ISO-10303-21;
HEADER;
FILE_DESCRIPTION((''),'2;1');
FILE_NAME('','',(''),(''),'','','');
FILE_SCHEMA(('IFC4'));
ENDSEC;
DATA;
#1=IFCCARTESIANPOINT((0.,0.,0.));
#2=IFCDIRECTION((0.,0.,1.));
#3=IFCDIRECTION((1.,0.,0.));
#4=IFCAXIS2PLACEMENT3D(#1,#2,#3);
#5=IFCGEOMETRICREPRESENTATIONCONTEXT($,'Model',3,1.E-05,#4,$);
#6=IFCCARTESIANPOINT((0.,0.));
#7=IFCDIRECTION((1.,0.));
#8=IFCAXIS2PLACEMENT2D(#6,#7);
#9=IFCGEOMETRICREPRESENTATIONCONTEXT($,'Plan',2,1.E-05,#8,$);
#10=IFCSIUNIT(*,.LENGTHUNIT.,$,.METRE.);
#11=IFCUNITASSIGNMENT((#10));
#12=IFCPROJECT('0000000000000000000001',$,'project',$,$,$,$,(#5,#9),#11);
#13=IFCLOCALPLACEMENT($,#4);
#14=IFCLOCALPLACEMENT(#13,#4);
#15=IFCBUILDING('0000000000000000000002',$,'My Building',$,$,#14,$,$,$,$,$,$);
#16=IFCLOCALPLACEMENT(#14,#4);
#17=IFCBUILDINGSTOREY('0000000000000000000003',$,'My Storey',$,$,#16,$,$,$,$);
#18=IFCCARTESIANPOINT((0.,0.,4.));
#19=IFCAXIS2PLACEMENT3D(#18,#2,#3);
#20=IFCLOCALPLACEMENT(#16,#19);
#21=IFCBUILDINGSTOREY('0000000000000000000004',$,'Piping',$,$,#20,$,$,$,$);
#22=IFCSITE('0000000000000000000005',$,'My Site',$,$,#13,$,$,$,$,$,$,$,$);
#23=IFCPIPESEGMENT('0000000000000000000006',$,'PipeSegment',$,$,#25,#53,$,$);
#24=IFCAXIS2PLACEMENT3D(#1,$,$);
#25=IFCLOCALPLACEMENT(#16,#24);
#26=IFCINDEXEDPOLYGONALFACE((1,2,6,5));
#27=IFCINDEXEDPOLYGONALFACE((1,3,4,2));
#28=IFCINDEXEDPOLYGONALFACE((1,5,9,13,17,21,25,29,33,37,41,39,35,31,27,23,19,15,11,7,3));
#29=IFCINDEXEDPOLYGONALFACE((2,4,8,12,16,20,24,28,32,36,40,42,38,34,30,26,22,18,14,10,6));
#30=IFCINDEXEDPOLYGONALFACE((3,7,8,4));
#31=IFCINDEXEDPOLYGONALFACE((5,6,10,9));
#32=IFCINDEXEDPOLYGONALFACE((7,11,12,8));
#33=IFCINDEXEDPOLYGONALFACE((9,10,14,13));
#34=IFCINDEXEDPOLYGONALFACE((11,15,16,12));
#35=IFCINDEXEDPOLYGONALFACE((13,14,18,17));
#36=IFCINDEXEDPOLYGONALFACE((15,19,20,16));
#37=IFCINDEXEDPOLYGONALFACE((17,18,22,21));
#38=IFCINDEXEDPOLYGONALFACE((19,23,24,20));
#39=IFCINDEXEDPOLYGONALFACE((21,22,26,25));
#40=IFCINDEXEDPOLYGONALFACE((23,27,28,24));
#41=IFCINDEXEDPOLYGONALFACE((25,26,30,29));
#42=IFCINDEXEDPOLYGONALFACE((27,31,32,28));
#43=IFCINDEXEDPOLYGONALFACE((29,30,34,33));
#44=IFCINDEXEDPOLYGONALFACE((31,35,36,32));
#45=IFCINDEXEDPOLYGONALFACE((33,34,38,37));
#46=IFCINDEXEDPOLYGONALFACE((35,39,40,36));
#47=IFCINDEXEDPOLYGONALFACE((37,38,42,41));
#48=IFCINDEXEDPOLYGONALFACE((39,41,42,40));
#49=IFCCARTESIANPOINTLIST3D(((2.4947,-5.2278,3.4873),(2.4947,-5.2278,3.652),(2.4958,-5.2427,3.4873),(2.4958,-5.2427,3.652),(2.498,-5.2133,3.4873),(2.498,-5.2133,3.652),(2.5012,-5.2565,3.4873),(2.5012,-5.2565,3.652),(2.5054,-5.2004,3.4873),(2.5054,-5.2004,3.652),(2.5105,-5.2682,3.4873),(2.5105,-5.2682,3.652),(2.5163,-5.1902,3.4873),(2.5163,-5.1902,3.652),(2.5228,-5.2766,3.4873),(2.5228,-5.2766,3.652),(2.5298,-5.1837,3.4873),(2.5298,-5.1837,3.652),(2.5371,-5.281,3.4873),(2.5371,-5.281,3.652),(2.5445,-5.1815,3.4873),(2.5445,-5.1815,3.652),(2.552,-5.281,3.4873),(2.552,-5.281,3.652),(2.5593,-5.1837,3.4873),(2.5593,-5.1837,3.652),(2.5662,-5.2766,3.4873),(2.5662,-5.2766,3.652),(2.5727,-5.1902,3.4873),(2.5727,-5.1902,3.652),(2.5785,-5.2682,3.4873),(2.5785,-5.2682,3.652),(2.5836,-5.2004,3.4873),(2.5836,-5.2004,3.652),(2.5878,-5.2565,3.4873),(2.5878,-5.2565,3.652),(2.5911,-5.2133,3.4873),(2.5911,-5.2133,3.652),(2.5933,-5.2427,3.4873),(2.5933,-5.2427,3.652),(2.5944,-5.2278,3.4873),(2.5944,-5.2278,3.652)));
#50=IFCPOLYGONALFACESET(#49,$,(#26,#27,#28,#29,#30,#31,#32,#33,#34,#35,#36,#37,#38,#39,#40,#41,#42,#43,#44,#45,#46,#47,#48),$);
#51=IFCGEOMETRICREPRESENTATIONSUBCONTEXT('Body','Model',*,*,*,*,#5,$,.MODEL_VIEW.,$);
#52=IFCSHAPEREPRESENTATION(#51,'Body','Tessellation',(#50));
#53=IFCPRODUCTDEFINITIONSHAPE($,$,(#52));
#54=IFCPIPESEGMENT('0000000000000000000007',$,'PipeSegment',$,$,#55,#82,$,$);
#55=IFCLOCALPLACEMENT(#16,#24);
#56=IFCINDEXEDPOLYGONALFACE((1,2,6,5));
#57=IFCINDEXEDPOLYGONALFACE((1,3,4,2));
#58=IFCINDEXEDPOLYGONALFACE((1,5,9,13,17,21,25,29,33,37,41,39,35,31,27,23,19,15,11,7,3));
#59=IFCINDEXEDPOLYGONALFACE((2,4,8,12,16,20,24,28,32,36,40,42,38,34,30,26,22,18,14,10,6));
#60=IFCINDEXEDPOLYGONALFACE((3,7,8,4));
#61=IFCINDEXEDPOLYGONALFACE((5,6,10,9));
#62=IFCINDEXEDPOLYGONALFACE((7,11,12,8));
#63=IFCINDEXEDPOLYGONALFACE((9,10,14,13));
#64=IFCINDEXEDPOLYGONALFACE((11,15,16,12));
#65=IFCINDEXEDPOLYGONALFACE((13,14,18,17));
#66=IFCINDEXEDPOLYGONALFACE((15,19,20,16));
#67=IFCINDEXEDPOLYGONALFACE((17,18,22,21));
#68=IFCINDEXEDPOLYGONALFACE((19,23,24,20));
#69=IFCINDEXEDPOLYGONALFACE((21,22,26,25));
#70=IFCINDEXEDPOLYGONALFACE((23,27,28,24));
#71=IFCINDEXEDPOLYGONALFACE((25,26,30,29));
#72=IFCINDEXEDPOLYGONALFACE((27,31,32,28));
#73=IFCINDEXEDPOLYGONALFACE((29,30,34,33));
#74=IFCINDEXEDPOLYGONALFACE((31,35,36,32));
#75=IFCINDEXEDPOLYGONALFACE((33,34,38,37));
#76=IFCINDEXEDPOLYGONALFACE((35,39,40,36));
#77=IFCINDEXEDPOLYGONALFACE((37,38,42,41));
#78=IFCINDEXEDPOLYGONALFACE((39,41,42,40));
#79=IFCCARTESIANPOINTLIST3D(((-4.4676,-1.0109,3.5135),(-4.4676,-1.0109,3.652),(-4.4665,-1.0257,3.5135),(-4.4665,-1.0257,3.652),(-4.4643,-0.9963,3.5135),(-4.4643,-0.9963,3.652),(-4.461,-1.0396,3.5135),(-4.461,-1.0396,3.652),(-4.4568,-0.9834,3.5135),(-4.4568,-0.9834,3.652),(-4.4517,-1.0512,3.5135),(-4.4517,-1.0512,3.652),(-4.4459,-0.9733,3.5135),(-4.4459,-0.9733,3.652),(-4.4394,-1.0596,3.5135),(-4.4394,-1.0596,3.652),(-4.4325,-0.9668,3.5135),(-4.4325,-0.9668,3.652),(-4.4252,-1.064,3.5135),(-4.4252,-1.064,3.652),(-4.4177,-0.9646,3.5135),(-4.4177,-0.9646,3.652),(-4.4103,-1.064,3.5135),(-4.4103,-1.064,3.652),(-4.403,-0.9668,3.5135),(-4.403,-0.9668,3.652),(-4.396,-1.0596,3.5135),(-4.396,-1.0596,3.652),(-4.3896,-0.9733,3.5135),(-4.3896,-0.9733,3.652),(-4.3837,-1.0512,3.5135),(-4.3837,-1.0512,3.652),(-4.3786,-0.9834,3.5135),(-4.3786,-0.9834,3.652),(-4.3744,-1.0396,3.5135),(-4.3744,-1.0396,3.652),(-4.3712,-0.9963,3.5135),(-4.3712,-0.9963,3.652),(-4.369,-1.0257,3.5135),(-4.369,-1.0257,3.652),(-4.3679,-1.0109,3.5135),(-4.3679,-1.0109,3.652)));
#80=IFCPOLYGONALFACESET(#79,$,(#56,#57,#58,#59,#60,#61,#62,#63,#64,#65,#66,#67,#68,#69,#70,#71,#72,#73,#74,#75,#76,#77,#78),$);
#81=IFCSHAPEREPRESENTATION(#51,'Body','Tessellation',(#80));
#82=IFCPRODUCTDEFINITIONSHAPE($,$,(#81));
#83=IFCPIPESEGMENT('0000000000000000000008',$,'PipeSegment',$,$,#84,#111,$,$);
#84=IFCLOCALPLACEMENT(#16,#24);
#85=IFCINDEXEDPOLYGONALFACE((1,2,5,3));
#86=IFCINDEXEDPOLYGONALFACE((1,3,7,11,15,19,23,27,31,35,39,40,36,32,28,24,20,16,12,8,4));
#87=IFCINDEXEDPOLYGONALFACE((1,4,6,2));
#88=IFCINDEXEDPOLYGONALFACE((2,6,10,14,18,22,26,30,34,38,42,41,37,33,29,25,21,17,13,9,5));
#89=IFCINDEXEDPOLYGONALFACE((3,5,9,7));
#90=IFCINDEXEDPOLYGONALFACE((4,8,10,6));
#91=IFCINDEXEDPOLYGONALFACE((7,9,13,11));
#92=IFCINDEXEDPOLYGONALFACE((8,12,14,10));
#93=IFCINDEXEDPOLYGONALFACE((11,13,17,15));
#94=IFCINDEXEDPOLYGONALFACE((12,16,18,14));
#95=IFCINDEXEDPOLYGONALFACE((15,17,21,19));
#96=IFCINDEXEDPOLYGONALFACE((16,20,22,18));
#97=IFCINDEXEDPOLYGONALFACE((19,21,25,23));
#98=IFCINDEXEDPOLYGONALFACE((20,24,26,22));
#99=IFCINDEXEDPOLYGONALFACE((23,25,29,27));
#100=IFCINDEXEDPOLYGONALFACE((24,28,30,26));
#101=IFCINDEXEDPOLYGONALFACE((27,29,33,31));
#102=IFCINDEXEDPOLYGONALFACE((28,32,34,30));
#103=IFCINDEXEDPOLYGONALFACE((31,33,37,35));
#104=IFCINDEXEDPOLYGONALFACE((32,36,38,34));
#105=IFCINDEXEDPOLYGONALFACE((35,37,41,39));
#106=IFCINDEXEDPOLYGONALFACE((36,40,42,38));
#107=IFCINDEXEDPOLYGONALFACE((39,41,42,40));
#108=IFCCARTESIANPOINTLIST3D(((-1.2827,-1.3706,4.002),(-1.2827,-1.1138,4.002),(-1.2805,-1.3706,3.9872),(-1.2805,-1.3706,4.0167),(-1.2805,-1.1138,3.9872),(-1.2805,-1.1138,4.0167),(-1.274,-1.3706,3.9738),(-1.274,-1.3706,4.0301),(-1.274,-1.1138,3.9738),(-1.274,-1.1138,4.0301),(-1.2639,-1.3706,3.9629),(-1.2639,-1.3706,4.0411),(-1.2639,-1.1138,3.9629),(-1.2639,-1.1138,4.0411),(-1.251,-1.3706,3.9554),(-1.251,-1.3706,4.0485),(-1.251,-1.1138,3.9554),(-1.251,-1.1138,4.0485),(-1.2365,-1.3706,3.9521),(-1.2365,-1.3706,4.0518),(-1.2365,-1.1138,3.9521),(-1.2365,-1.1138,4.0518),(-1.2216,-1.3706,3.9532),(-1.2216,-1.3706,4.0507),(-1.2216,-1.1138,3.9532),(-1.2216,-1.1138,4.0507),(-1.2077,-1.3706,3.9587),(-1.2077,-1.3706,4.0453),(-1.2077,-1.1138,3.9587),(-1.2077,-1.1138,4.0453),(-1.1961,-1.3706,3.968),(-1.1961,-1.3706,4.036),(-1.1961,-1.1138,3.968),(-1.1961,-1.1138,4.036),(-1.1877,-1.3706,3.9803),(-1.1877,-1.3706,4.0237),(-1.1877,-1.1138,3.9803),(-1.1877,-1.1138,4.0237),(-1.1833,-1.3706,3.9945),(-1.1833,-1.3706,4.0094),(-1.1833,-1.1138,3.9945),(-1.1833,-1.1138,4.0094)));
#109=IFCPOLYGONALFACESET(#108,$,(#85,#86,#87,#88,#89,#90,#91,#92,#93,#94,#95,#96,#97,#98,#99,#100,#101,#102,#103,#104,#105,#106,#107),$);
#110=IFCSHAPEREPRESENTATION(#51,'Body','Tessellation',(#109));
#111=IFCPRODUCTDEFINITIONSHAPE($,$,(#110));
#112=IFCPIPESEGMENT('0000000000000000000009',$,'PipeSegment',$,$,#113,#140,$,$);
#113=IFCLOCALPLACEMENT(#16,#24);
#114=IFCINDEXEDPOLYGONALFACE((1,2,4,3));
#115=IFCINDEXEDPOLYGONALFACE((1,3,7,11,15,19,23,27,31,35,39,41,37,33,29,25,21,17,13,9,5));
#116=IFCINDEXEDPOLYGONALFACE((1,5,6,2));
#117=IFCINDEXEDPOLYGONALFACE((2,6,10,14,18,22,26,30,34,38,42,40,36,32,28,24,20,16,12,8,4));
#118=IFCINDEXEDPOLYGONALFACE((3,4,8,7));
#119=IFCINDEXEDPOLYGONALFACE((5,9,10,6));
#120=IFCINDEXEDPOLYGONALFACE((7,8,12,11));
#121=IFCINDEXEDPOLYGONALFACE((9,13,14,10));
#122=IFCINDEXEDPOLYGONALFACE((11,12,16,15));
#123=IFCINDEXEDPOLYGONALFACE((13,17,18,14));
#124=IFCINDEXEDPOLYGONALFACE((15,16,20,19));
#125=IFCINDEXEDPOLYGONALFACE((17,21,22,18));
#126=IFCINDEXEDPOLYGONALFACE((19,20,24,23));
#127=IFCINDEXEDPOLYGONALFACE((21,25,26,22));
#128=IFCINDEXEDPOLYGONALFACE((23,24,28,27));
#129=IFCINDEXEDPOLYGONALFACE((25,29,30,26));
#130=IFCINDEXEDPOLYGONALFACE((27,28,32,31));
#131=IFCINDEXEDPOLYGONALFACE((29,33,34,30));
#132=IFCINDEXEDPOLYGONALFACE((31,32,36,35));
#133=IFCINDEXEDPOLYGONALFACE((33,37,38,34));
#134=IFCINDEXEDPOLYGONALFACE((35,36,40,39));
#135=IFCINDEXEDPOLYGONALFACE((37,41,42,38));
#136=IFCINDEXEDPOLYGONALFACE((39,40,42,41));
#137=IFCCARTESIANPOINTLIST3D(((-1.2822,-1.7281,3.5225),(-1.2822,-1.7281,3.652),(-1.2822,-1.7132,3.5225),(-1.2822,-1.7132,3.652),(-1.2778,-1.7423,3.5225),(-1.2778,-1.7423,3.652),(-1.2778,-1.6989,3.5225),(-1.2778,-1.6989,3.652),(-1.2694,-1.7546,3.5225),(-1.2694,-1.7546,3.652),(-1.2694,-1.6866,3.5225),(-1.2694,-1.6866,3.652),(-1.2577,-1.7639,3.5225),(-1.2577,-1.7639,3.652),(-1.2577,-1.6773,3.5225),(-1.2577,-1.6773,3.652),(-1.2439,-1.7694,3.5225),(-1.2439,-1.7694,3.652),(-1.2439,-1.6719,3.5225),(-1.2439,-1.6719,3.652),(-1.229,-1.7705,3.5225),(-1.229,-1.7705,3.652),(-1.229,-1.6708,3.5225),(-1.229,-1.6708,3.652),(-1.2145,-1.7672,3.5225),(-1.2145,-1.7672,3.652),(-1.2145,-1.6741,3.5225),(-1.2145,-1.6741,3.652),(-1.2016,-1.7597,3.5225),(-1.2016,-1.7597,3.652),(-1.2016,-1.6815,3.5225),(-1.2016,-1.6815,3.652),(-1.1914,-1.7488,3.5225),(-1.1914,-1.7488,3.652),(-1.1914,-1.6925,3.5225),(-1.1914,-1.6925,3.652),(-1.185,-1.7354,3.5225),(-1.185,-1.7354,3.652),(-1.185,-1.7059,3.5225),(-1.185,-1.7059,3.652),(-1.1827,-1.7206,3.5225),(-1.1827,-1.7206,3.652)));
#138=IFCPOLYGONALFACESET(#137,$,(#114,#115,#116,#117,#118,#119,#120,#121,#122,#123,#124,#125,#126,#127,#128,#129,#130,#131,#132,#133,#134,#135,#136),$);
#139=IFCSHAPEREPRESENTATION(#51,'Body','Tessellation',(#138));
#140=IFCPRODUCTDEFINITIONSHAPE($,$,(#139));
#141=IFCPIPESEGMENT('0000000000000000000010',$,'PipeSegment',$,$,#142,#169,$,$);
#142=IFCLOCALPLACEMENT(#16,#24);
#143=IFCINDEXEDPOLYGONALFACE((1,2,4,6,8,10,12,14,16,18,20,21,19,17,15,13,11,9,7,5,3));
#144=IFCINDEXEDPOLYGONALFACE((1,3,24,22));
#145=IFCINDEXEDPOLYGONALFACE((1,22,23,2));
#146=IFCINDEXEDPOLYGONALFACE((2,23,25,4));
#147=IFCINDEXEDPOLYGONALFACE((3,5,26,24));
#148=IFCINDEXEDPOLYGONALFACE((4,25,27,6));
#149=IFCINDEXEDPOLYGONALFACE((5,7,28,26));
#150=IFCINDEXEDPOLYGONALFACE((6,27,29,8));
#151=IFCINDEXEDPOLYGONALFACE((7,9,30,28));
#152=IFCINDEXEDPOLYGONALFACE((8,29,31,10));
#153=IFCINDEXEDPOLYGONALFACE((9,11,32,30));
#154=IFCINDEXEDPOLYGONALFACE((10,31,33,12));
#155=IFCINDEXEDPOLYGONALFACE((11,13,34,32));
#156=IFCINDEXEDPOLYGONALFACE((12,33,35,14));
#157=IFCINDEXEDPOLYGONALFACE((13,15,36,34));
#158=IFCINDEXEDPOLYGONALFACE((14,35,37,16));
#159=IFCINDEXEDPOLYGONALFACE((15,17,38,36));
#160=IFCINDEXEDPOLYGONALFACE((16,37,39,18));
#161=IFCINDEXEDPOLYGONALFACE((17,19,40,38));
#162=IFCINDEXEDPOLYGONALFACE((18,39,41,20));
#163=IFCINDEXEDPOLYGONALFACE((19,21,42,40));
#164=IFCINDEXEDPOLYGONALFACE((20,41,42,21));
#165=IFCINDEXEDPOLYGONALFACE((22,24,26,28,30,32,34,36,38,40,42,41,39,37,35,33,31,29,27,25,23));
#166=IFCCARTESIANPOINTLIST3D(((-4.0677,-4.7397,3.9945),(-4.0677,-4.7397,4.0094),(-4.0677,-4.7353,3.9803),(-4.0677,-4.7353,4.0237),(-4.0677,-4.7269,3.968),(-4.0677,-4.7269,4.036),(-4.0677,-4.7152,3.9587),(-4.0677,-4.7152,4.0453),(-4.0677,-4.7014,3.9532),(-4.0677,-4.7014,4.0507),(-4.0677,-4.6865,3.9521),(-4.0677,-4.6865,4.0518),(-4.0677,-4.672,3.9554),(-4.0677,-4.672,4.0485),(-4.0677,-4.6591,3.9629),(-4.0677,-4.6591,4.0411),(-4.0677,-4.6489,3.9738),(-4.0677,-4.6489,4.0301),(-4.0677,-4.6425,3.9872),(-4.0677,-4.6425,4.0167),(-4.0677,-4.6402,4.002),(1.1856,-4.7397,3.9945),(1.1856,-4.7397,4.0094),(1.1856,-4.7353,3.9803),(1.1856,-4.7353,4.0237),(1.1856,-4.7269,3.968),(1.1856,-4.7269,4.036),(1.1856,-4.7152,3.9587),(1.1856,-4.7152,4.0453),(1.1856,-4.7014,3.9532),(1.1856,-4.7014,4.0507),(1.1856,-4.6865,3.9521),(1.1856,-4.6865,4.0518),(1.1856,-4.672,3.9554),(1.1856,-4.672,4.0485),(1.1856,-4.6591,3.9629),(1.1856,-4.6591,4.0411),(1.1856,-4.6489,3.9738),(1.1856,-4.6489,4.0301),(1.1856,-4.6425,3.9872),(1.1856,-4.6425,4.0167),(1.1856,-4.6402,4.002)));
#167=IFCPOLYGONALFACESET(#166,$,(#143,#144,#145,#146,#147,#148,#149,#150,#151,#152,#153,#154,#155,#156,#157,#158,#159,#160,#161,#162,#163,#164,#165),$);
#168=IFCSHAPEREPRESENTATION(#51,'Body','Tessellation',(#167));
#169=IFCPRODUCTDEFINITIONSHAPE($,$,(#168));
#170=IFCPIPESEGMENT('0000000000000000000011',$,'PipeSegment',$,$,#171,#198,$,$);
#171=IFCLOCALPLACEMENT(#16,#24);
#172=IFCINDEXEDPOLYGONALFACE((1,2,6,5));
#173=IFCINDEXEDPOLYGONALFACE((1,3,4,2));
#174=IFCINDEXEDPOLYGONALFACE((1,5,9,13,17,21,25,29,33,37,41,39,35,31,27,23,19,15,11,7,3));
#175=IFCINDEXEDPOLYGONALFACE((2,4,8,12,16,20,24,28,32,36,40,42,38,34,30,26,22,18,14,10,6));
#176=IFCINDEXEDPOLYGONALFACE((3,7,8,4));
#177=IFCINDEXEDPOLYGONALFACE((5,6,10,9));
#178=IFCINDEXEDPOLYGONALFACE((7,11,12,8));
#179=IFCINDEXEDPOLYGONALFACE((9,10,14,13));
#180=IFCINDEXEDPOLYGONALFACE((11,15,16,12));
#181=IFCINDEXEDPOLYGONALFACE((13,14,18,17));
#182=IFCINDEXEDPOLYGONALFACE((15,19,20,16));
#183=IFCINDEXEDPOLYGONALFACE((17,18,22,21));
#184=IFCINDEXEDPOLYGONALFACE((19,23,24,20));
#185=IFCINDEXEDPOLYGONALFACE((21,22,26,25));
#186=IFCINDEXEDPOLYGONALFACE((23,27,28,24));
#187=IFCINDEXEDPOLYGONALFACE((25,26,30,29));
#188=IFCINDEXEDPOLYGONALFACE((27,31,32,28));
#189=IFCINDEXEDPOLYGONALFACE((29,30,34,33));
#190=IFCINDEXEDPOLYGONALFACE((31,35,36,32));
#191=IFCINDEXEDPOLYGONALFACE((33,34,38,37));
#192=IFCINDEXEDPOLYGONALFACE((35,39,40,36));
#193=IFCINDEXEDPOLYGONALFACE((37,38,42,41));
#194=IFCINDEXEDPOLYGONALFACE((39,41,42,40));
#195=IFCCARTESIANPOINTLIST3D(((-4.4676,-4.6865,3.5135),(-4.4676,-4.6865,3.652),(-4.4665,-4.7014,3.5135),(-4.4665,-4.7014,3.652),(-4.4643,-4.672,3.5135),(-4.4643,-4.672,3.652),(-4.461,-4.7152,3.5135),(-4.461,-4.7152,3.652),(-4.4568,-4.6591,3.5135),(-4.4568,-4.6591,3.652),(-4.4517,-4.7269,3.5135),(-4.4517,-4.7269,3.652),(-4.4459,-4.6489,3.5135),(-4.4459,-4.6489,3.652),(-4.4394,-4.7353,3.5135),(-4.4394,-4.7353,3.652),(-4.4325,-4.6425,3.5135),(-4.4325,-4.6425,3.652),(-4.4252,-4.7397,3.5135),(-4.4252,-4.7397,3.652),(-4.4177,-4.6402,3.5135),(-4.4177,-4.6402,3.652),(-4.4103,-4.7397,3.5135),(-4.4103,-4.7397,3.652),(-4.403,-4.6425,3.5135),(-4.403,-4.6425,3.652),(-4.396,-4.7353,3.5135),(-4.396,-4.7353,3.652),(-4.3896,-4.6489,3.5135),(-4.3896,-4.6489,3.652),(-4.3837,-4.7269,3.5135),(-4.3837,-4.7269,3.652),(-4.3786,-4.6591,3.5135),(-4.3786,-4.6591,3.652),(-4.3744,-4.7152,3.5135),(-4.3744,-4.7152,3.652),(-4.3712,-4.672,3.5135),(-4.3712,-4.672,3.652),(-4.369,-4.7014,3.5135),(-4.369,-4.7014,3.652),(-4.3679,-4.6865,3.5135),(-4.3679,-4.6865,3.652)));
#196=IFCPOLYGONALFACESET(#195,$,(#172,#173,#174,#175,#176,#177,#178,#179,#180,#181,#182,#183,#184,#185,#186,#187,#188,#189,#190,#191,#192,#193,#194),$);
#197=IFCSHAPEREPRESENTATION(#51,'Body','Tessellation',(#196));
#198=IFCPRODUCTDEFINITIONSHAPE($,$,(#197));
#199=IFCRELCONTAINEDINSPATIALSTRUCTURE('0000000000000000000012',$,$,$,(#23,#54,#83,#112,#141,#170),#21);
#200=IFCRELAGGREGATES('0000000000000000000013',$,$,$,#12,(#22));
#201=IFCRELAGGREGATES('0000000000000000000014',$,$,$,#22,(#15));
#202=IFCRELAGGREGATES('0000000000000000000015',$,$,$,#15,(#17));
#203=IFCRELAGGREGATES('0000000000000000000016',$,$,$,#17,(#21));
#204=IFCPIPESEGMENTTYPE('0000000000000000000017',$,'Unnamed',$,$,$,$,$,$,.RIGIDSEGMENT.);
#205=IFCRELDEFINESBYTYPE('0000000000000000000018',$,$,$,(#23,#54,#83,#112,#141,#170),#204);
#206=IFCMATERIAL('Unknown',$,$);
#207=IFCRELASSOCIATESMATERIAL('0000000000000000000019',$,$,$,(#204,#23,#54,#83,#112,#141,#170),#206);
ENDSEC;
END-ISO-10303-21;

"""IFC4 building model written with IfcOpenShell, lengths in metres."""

from ifc_helpers import new_model, si_unit, frame, origin_with_axes, origin_2d_with_axis, place, context, subcontext, project, spatial, circle, extrude, material, material_profile, profile_set, profile_usage, type_object, element, save


model = new_model("IFC4")

# Units and contexts
model_context = context("Model", 3, precision=1e-05, world=origin_with_axes())
plan_context = context("Plan", 2, precision=1e-05, world=origin_2d_with_axis())
body_context = subcontext(model_context, "Body", "Model", "MODEL_VIEW")
ifc_project = project(units=[si_unit("LENGTHUNIT", "METRE")], contexts=[model_context, plan_context])

# Site, building, storeys
site_placement = place(None, origin_with_axes())
site = spatial("IfcSite", under=ifc_project, at=site_placement, Name="My Site")
building_placement = place(site_placement, origin_with_axes())
building = spatial("IfcBuilding", under=site, at=building_placement, Name="My Building")
storey_1_placement = place(building_placement, origin_with_axes())
storey_1 = spatial("IfcBuildingStorey", under=building, at=storey_1_placement, Name="My Storey")
storey_2_placement = place(storey_1_placement, frame((0.0, 0.0, 4.0), z_axis=(0.0, 0.0, 1.0), x_axis=(1.0, 0.0, 0.0)))
storey_2 = spatial("IfcBuildingStorey", under=storey_1, at=storey_2_placement, Name="Piping")

# Pipe segments
ifc_material = material(Name="Unknown")
ifc_material_profile_1 = material_profile(ifc_material, circle(Radius=0.05))
ifc_profile_set_1 = profile_set([ifc_material_profile_1])
pipe_segment_type = type_object("IfcPipeSegmentType", Name="Unnamed", PredefinedType="RIGIDSEGMENT", material=ifc_profile_set_1)
ifc_profile_usage_1 = profile_usage(ifc_profile_set_1, cardinal=5)
pipe_segment_1_placement = place(storey_2_placement, frame((2.5445, -5.2315, -0.348), z_axis=(0.0, 0.0, -1.0), x_axis=(0.0, 1.0, 0.0)))
element("IfcPipeSegment", 1, at=pipe_segment_1_placement, inside=storey_2, type_object=pipe_segment_type, material=ifc_profile_usage_1, Name="PipeSegment", context=body_context, shape_type="SweptSolid", body=[
    extrude(circle(Radius=0.05), origin_with_axes(), (0.0, 0.0, 1.0), 0.1647),
])
ifc_profile_usage_2 = profile_usage(ifc_profile_set_1, cardinal=5)
pipe_segment_2_placement = place(storey_2_placement, frame((-4.4177, -1.0146, -0.348), z_axis=(0.0, 0.0, -1.0), x_axis=(0.0, 1.0, 0.0)))
element("IfcPipeSegment", 2, at=pipe_segment_2_placement, inside=storey_2, type_object=pipe_segment_type, material=ifc_profile_usage_2, Name="PipeSegment", context=body_context, shape_type="SweptSolid", body=[
    extrude(circle(Radius=0.05), origin_with_axes(), (0.0, 0.0, 1.0), 0.1385),
])
ifc_profile_usage_3 = profile_usage(ifc_profile_set_1, cardinal=5)
pipe_segment_3_placement = place(storey_2_placement, frame((-1.2327, -1.3706, 0.002), z_axis=(0.0, 1.0, 0.000001), x_axis=(-1.0, 0.0, 0.0)))
element("IfcPipeSegment", 3, at=pipe_segment_3_placement, inside=storey_2, type_object=pipe_segment_type, material=ifc_profile_usage_3, Name="PipeSegment", context=body_context, shape_type="SweptSolid", body=[
    extrude(circle(Radius=0.05), origin_with_axes(), (0.0, 0.0, 1.0), 0.2568),
])
ifc_profile_usage_4 = profile_usage(ifc_profile_set_1, cardinal=5)
pipe_segment_4_placement = place(storey_2_placement, frame((-1.2327, -1.7206, -0.348), z_axis=(0.0, 0.0, -1.0), x_axis=(1.0, 0.0, 0.0)))
element("IfcPipeSegment", 4, at=pipe_segment_4_placement, inside=storey_2, type_object=pipe_segment_type, material=ifc_profile_usage_4, Name="PipeSegment", context=body_context, shape_type="SweptSolid", body=[
    extrude(circle(Radius=0.05), origin_with_axes(), (0.0, 0.0, 1.0), 0.1294),
])
ifc_profile_usage_5 = profile_usage(ifc_profile_set_1, cardinal=5)
pipe_segment_5_placement = place(storey_2_placement, frame((-4.0677, -4.6902, 0.002), z_axis=(1.0, 0.0, 0.0), x_axis=(0.0, 1.0, 0.0)))
element("IfcPipeSegment", 5, at=pipe_segment_5_placement, inside=storey_2, type_object=pipe_segment_type, material=ifc_profile_usage_5, Name="PipeSegment", context=body_context, shape_type="SweptSolid", body=[
    extrude(circle(Radius=0.05), origin_with_axes(), (0.0, 0.0, 1.0), 5.2533),
])
ifc_profile_usage_6 = profile_usage(ifc_profile_set_1, cardinal=5)
pipe_segment_6_placement = place(storey_2_placement, frame((-4.4177, -4.6902, -0.348), z_axis=(0.0, 0.0, -1.0), x_axis=(0.0, 1.0, 0.0)))
element("IfcPipeSegment", 6, at=pipe_segment_6_placement, inside=storey_2, type_object=pipe_segment_type, material=ifc_profile_usage_6, Name="PipeSegment", context=body_context, shape_type="SweptSolid", body=[
    extrude(circle(Radius=0.05), origin_with_axes(), (0.0, 0.0, 1.0), 0.1385),
])

save(model, "model.ifc")
